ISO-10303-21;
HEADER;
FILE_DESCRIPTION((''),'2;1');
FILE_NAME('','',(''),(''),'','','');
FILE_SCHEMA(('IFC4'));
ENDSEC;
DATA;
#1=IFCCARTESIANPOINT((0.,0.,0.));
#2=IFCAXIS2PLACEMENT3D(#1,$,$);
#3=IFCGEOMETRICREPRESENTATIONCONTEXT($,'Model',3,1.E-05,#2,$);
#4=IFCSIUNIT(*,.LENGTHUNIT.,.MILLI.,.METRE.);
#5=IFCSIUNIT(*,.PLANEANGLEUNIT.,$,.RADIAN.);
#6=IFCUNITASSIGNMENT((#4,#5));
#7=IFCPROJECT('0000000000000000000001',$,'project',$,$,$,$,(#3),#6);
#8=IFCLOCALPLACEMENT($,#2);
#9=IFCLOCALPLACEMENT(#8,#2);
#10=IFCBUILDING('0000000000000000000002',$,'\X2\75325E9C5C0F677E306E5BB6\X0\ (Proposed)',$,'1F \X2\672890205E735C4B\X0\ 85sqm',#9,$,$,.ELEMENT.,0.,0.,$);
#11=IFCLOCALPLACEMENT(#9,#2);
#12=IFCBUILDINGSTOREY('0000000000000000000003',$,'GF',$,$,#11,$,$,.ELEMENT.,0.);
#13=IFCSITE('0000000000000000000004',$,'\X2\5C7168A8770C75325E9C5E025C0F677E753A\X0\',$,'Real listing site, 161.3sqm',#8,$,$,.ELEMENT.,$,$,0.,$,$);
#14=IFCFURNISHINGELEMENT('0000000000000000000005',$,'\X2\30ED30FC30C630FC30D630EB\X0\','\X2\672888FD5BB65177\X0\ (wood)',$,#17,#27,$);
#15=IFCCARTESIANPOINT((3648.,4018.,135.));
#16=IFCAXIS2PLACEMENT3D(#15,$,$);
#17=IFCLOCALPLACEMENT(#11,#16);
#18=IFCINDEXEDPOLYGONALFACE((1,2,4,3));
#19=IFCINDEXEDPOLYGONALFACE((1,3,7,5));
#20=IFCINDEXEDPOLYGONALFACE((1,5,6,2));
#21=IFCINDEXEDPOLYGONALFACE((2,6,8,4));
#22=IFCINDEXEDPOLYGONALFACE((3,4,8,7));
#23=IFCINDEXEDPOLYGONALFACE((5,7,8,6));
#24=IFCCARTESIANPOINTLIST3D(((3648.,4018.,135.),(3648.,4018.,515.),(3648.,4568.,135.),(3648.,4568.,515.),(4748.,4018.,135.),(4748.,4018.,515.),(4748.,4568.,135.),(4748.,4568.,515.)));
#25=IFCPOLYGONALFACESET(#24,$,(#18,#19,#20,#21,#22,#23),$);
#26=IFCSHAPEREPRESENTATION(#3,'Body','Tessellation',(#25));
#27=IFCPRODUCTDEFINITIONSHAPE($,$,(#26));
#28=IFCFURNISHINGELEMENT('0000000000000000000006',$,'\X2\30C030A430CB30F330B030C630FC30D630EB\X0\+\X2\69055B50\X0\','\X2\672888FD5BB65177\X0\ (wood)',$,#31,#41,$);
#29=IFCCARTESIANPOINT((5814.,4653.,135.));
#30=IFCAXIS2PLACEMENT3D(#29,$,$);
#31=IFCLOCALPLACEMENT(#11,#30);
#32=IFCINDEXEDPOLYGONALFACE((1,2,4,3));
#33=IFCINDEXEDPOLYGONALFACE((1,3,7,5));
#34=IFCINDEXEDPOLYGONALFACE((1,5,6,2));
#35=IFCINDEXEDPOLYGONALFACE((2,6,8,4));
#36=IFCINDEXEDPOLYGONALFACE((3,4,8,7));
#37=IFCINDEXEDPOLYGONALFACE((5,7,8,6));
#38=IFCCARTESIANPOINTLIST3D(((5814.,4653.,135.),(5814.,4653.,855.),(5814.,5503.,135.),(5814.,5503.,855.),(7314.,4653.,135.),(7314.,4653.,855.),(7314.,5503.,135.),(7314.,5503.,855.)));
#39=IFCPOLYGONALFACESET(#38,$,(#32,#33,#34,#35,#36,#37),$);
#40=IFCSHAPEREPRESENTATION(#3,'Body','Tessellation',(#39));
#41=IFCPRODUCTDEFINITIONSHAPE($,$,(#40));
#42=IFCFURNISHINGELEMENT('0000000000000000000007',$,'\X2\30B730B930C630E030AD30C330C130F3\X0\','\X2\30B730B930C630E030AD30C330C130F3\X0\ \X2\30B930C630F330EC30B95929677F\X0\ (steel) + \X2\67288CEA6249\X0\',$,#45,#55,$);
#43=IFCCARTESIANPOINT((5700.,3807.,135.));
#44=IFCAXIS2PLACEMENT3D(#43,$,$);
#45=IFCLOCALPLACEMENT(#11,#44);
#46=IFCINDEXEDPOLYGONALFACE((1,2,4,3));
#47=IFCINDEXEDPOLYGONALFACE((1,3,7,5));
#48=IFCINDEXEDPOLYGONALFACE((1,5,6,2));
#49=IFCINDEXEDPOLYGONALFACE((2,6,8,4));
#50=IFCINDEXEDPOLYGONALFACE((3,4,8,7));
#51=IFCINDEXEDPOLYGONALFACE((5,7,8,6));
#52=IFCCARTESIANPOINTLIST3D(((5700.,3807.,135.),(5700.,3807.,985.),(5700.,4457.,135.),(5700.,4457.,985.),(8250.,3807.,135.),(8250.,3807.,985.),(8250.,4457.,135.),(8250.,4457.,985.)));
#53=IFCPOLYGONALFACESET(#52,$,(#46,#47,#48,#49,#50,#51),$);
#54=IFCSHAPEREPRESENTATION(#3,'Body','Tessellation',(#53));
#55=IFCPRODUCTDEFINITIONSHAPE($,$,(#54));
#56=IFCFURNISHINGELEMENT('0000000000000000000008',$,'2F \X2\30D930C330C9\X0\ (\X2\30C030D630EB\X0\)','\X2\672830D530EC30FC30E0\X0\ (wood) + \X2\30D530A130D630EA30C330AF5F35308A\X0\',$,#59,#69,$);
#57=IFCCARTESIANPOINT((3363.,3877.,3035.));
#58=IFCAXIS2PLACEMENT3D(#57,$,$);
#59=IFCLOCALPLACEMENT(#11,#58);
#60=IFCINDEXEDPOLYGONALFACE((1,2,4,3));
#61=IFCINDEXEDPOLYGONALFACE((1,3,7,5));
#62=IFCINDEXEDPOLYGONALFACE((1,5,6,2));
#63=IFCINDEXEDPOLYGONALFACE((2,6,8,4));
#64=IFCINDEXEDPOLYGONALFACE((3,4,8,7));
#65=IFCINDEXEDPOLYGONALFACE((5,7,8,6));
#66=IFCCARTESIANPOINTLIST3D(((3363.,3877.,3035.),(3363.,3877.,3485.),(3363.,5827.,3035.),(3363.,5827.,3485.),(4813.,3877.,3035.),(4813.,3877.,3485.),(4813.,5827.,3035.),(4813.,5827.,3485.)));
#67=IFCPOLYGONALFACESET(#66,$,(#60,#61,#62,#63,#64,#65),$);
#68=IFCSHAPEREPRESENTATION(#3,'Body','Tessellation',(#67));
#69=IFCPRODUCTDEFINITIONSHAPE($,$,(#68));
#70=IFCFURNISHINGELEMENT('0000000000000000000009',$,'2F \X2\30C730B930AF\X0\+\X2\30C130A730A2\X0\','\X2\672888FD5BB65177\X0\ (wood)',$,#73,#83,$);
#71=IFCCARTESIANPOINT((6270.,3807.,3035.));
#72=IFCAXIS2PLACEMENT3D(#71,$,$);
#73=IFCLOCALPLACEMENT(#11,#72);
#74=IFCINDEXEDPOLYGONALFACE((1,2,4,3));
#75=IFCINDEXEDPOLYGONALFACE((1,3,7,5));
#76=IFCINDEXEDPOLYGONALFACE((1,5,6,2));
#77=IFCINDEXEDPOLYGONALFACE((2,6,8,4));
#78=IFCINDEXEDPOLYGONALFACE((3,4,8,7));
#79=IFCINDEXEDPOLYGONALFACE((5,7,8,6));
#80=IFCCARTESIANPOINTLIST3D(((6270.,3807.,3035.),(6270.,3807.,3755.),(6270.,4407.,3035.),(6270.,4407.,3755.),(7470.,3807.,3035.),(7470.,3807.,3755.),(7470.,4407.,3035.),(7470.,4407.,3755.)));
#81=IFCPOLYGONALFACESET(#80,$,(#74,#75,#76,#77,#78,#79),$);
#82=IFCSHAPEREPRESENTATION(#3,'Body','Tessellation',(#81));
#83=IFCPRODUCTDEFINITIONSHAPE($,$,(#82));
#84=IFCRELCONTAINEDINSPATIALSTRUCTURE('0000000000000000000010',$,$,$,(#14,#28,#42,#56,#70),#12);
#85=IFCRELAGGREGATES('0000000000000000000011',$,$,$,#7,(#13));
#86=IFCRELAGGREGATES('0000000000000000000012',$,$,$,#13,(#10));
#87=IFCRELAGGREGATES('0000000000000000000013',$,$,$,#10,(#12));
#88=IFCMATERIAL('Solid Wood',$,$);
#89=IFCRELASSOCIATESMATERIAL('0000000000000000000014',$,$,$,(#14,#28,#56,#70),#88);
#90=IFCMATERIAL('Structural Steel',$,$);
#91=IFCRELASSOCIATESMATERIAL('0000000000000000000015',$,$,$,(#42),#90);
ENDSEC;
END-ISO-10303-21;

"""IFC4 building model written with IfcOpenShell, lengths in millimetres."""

from ifc_helpers import new_model, si_unit, frame, frame_2d, origin, place, context, project, spatial, rectangle, extrude, material, element, save


model = new_model("IFC4")

# Units and contexts
model_context = context("Model", 3, precision=1e-05, world=origin())
ifc_project = project(units=[si_unit("LENGTHUNIT", "METRE", prefix="MILLI"), si_unit("PLANEANGLEUNIT", "RADIAN")], contexts=[model_context])

# Site, building, storey
site_placement = place(None, origin())
site = spatial("IfcSite", under=ifc_project, at=site_placement, Name="山梨県甲府市小松町", ObjectType="Real listing site, 161.3sqm", CompositionType="ELEMENT", RefElevation=0.0)
building_placement = place(site_placement, origin())
building = spatial("IfcBuilding", under=site, at=building_placement, Name="甲府小松の家 (Proposed)", ObjectType="1F 木造平屋 85sqm", CompositionType="ELEMENT", ElevationOfRefHeight=0.0, ElevationOfTerrain=0.0)
storey_placement = place(building_placement, origin())
storey = spatial("IfcBuildingStorey", under=building, at=storey_placement, Name="GF", CompositionType="ELEMENT", Elevation=0.0)

# Shared definitions
ifc_material_1 = material(Name="Solid Wood")

# Shared definitions
ifc_material_2 = material(Name="Structural Steel")

# Furnishing elements
furnishing_1_placement = place(storey_placement, frame((3648.0, 4018.0, 135.0)))
element("IfcFurnishingElement", 1, at=furnishing_1_placement, inside=storey, material=ifc_material_1, Name="ローテーブル", Description="木製家具 (wood)", context=model_context, shape_type="SweptSolid", body=[
    extrude(rectangle(XDim=1100.0, YDim=550.0, at=frame_2d((550.0, 275.0))), frame((3648.0, 4018.0, 135.0)), (0.0, 0.0, 1.0), 380.0),
])
furnishing_2_placement = place(storey_placement, frame((5814.0, 4653.0, 135.0)))
element("IfcFurnishingElement", 2, at=furnishing_2_placement, inside=storey, material=ifc_material_1, Name="ダイニングテーブル+椅子", Description="木製家具 (wood)", context=model_context, shape_type="SweptSolid", body=[
    extrude(rectangle(XDim=1500.0, YDim=850.0, at=frame_2d((750.0, 425.0))), frame((5814.0, 4653.0, 135.0)), (0.0, 0.0, 1.0), 720.0),
])
furnishing_3_placement = place(storey_placement, frame((5700.0, 3807.0, 135.0)))
element("IfcFurnishingElement", 3, at=furnishing_3_placement, inside=storey, material=ifc_material_2, Name="システムキッチン", Description="システムキッチン ステンレス天板 (steel) + 木質扉", context=model_context, shape_type="SweptSolid", body=[
    extrude(rectangle(XDim=2550.0, YDim=650.0, at=frame_2d((1275.0, 325.0))), frame((5700.0, 3807.0, 135.0)), (0.0, 0.0, 1.0), 850.0),
])
furnishing_4_placement = place(storey_placement, frame((3363.0, 3877.0, 3035.0)))
element("IfcFurnishingElement", 4, at=furnishing_4_placement, inside=storey, material=ifc_material_1, Name="2F ベッド (ダブル)", Description="木フレーム (wood) + ファブリック張り", context=model_context, shape_type="SweptSolid", body=[
    extrude(rectangle(XDim=1450.0, YDim=1950.0, at=frame_2d((725.0, 975.0))), frame((3363.0, 3877.0, 3035.0)), (0.0, 0.0, 1.0), 450.0),
])
furnishing_5_placement = place(storey_placement, frame((6270.0, 3807.0, 3035.0)))
element("IfcFurnishingElement", 5, at=furnishing_5_placement, inside=storey, material=ifc_material_1, Name="2F デスク+チェア", Description="木製家具 (wood)", context=model_context, shape_type="SweptSolid", body=[
    extrude(rectangle(XDim=1200.0, YDim=600.0, at=frame_2d((600.0, 300.0))), frame((6270.0, 3807.0, 3035.0)), (0.0, 0.0, 1.0), 720.0),
])

save(model, "model.ifc")
